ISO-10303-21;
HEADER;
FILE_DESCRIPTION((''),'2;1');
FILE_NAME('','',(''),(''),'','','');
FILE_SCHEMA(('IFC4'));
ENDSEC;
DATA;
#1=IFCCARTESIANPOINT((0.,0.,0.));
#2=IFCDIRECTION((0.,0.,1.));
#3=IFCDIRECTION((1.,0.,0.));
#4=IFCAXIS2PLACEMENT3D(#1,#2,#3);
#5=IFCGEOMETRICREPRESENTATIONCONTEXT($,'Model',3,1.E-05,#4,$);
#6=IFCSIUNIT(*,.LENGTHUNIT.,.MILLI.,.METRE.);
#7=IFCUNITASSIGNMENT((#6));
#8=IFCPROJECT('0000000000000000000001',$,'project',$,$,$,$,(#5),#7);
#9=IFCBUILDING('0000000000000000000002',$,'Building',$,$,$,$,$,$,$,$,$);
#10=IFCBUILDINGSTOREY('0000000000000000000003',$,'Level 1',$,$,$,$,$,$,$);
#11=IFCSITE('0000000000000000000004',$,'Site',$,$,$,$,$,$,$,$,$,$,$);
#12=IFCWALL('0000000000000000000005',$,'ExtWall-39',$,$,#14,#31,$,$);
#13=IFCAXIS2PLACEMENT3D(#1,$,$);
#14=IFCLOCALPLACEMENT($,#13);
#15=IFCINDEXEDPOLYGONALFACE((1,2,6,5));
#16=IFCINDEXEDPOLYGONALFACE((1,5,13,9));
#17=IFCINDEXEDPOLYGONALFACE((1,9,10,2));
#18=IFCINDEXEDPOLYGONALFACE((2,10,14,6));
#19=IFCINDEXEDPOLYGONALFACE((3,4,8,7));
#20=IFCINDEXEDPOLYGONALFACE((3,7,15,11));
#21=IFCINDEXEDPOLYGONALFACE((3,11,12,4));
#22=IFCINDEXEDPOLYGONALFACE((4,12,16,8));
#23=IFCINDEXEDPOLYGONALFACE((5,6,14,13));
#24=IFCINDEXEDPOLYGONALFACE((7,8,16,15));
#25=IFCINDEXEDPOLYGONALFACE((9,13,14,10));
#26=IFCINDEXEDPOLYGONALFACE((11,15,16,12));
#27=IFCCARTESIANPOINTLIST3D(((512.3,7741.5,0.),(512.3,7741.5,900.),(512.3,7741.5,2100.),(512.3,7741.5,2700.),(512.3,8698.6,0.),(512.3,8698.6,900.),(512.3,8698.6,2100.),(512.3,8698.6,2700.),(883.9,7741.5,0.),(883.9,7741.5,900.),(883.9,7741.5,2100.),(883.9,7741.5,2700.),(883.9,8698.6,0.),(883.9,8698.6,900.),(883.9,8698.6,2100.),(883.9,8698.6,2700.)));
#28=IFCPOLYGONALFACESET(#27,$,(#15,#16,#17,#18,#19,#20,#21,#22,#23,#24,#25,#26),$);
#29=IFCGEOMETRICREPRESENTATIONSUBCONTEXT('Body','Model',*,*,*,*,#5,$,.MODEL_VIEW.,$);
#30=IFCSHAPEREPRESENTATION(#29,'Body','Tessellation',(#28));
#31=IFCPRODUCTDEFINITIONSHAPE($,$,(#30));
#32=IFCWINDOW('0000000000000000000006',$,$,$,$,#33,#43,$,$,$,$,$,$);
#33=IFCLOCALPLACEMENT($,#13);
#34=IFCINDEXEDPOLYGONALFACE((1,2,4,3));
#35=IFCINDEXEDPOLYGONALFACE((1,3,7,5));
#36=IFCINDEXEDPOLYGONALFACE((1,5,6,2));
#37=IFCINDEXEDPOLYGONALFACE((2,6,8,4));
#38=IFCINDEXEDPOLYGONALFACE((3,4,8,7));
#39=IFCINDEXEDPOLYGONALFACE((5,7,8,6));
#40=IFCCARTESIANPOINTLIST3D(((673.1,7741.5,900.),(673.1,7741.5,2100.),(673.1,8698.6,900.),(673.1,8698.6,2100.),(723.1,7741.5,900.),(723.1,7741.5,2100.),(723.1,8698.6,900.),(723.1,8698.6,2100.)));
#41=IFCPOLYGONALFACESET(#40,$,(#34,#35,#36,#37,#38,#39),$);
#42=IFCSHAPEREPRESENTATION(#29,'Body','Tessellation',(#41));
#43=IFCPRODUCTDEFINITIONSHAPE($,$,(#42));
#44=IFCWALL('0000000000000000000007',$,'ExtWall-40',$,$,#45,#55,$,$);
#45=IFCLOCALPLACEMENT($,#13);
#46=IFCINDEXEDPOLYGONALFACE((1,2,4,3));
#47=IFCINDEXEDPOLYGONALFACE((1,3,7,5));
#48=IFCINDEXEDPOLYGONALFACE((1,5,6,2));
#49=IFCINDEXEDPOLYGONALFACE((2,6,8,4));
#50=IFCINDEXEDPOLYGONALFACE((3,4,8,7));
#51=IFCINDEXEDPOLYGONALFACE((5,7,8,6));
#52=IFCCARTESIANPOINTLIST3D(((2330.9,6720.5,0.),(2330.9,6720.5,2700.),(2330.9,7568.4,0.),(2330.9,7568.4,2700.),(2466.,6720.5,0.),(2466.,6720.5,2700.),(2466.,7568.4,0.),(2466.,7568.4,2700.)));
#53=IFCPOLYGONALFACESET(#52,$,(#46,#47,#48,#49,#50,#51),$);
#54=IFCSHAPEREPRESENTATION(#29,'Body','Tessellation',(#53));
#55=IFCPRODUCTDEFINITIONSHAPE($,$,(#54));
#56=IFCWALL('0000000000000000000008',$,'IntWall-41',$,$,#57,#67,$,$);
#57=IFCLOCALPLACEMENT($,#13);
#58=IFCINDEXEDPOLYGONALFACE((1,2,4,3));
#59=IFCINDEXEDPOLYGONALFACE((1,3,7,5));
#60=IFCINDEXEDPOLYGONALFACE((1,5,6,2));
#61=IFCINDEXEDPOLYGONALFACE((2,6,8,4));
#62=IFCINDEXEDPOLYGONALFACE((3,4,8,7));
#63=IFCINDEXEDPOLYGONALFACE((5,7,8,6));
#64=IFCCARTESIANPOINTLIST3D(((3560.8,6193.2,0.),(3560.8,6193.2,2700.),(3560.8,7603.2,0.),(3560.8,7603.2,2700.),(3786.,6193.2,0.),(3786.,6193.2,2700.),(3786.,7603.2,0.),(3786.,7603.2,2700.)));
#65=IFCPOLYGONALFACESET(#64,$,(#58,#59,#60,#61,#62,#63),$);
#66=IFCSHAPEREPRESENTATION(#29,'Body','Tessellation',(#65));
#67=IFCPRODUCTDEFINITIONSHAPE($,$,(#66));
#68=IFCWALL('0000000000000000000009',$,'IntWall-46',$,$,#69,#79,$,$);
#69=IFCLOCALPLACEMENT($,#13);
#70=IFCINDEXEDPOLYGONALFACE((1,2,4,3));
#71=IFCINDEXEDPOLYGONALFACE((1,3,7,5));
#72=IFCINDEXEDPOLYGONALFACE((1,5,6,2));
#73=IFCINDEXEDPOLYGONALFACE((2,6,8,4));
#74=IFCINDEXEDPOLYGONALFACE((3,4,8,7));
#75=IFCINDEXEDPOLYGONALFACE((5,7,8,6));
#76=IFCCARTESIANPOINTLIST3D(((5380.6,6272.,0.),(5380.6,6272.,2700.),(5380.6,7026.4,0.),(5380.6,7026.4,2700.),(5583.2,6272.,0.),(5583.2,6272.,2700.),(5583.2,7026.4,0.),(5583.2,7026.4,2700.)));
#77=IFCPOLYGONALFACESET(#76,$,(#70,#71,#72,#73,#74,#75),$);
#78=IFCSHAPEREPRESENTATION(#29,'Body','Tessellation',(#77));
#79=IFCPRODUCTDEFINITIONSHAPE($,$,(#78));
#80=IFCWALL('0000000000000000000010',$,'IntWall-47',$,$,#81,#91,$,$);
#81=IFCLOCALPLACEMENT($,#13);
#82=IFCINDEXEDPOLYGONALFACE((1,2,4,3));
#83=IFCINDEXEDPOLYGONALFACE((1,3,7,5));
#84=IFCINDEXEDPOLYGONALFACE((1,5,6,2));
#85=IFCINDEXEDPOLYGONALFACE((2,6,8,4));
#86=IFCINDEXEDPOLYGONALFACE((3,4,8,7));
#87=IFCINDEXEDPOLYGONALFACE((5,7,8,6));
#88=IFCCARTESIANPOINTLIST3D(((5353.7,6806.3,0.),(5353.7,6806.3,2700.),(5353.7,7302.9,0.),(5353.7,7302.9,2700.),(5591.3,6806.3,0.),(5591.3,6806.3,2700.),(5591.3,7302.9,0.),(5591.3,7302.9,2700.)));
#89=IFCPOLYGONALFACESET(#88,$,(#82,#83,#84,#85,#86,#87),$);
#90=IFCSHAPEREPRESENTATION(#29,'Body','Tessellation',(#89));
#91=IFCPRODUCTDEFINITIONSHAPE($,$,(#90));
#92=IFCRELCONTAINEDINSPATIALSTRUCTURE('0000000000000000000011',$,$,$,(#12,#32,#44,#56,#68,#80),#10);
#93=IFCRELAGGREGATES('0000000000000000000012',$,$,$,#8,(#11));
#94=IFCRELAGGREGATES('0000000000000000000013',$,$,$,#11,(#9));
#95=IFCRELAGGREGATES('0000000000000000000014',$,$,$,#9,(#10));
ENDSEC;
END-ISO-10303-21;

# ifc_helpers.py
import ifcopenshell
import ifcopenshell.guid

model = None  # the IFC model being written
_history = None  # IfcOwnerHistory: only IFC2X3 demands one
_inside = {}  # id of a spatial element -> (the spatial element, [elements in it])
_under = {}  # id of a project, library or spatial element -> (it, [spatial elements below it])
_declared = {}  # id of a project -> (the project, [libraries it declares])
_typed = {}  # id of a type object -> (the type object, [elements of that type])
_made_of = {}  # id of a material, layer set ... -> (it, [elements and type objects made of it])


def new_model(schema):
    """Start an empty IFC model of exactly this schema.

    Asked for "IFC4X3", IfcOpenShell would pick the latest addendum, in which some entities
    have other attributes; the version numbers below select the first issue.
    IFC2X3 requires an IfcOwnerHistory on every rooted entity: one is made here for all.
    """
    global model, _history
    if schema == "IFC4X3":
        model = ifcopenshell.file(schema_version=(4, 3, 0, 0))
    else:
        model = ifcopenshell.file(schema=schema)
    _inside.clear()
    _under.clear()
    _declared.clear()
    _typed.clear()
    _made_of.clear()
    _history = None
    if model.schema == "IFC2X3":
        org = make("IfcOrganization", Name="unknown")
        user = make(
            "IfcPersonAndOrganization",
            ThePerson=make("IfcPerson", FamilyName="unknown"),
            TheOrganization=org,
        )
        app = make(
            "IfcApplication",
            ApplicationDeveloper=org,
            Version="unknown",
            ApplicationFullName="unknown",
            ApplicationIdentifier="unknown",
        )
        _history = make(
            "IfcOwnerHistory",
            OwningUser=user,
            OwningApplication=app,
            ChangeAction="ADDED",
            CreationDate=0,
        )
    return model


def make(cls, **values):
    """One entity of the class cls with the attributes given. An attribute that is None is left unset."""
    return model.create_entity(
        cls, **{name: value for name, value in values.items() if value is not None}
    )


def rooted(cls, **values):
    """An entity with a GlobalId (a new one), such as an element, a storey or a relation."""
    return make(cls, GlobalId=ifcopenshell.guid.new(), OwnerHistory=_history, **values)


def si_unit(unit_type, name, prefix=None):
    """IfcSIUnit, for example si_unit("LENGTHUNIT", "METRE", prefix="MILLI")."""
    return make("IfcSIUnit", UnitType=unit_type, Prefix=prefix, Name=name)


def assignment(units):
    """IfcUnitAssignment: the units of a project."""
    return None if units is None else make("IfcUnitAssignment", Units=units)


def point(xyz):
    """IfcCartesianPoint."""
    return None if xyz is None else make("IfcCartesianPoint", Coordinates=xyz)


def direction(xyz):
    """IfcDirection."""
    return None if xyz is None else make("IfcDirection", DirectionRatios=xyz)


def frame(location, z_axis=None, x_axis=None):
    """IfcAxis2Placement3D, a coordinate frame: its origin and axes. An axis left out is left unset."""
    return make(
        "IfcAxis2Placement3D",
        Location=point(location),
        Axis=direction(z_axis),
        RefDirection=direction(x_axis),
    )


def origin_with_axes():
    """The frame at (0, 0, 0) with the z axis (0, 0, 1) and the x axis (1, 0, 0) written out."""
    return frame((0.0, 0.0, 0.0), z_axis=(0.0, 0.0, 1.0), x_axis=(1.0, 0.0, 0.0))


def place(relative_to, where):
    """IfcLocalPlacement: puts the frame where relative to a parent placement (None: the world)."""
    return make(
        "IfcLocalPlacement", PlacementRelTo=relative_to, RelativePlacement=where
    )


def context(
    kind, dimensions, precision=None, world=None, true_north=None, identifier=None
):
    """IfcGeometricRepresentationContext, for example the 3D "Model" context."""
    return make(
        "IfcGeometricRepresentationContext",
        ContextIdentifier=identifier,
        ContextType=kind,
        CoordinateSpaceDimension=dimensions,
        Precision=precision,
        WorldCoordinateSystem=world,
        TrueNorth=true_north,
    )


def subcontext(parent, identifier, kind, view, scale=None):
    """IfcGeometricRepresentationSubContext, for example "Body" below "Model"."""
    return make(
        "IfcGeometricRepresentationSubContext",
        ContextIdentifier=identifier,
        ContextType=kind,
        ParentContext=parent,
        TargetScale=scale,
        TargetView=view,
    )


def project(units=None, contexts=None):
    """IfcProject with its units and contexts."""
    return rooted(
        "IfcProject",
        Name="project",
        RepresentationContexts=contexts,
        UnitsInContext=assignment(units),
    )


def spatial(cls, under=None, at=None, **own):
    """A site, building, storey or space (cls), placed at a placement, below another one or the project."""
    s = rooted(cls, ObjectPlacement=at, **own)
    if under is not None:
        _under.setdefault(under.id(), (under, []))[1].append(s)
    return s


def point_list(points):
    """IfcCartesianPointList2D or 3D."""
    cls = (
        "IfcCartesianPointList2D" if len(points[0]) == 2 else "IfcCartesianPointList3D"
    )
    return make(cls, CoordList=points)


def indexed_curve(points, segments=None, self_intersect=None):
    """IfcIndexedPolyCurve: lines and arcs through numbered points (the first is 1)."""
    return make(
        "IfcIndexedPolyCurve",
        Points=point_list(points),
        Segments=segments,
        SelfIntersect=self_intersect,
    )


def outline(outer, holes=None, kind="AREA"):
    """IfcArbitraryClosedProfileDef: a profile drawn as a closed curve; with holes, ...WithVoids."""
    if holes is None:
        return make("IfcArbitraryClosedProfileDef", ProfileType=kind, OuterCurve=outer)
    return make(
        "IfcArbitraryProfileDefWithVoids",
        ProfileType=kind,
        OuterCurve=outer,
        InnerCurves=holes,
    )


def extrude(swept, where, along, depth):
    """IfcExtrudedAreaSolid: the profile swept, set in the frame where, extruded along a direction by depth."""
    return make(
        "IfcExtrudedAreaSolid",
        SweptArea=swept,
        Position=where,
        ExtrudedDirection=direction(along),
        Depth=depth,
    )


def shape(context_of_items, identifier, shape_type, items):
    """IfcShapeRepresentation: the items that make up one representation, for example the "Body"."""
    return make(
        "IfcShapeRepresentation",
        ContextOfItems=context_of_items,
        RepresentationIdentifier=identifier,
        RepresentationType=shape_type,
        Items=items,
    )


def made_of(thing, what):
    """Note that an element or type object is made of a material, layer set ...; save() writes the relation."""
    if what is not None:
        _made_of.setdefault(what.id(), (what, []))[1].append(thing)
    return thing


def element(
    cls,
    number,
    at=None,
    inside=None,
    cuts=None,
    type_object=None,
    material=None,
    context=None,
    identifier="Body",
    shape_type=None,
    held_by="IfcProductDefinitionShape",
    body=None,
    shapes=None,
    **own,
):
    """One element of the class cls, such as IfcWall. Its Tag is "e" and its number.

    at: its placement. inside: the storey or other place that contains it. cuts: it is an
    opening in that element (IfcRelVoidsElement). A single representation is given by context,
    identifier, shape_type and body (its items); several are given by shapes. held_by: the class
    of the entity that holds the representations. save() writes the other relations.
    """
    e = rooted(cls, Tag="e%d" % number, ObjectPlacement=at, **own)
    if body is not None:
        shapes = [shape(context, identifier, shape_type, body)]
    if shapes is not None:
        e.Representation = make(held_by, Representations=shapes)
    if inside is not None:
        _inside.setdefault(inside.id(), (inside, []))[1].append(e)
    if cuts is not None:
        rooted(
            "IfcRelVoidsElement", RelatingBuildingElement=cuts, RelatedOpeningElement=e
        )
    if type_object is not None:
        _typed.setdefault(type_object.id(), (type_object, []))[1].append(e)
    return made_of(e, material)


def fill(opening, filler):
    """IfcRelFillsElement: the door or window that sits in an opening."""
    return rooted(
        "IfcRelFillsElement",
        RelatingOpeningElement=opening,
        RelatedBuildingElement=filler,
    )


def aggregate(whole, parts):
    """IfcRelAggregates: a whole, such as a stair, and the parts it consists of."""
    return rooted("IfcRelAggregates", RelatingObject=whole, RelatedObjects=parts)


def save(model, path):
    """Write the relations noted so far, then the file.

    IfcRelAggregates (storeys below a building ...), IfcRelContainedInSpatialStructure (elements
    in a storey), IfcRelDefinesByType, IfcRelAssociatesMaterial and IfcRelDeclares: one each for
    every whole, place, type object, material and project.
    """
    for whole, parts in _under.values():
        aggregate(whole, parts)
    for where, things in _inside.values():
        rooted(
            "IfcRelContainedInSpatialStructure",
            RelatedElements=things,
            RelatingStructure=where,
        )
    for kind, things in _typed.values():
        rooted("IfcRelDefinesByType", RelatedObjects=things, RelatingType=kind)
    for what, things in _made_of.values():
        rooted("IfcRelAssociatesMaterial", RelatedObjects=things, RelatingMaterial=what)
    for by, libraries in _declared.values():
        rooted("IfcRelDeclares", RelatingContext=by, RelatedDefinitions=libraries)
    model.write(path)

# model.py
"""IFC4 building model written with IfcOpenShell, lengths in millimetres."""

from ifc_helpers import new_model, si_unit, frame, origin_with_axes, place, context, subcontext, project, spatial, indexed_curve, outline, extrude, element, fill, save


model = new_model("IFC4")

# Units and contexts
model_context = context("Model", 3, precision=1e-05, world=origin_with_axes())
body_context = subcontext(model_context, "Body", "Model", "MODEL_VIEW")
ifc_project = project(units=[si_unit("LENGTHUNIT", "METRE", prefix="MILLI")], contexts=[model_context])

# Site, building, storey
site = spatial("IfcSite", under=ifc_project, Name="Site")
building = spatial("IfcBuilding", under=site, Name="Building")
storey = spatial("IfcBuildingStorey", under=building, Name="Level 1")

# Wall, opening, window
wall_1_placement = place(None, frame((698.1, 7741.5, 0.0), z_axis=(0.0, 0.0, 1.0), x_axis=(0.0, 1.0, 0.0)))
wall_1 = element("IfcWall", 1, at=wall_1_placement, inside=storey, Name="ExtWall-39", context=body_context, shape_type="SweptSolid", body=[
    extrude(outline(indexed_curve([(0.0, 0.0), (0.0, 371.6), (957.1, 371.6), (957.1, 0.0), (0.0, 0.0)], self_intersect=False)), frame((0.0, -185.8, 0.0), z_axis=(0.0, 0.0, 1.0), x_axis=(1.0, 0.0, 0.0)), (0.0, 0.0, 1.0), 2700.0),
])
opening_1_placement = place(wall_1_placement, frame((0.0, 0.0, 900.0), z_axis=(0.0, 0.0, 1.0), x_axis=(1.0, 0.0, 0.0)))
opening_1 = element("IfcOpeningElement", 2, at=opening_1_placement, cuts=wall_1, context=body_context, shape_type="SweptSolid", body=[
    extrude(outline(indexed_curve([(0.0, 0.0), (0.0, 471.6), (957.1, 471.6), (957.1, 0.0), (0.0, 0.0)], self_intersect=False)), frame((0.0, -235.8, 0.0), z_axis=(0.0, 0.0, 1.0), x_axis=(1.0, 0.0, 0.0)), (0.0, 0.0, 1.0), 1200.0),
])
window_placement = place(opening_1_placement, origin_with_axes())
window = element("IfcWindow", 3, at=window_placement, inside=storey, context=body_context, shape_type="SweptSolid", body=[
    extrude(outline(indexed_curve([(0.0, 0.0), (0.0, 50.0), (957.1, 50.0), (957.1, 0.0), (0.0, 0.0)], self_intersect=False)), frame((0.0, -25.0, 0.0), z_axis=(0.0, 0.0, 1.0), x_axis=(1.0, 0.0, 0.0)), (0.0, 0.0, 1.0), 1200.0),
])
fill(opening_1, window)

# Walls
wall_2_placement = place(None, frame((2398.4, 6720.5, 0.0), z_axis=(0.0, 0.0, 1.0), x_axis=(0.0, 1.0, 0.0)))
element("IfcWall", 4, at=wall_2_placement, inside=storey, Name="ExtWall-40", context=body_context, shape_type="SweptSolid", body=[
    extrude(outline(indexed_curve([(0.0, 0.0), (0.0, 135.1), (847.9, 135.1), (847.9, 0.0), (0.0, 0.0)], self_intersect=False)), frame((0.0, -67.6, 0.0), z_axis=(0.0, 0.0, 1.0), x_axis=(1.0, 0.0, 0.0)), (0.0, 0.0, 1.0), 2700.0),
])
wall_3_placement = place(None, frame((3673.4, 6193.2, 0.0), z_axis=(0.0, 0.0, 1.0), x_axis=(0.0, 1.0, 0.0)))
element("IfcWall", 5, at=wall_3_placement, inside=storey, Name="IntWall-41", context=body_context, shape_type="SweptSolid", body=[
    extrude(outline(indexed_curve([(0.0, 0.0), (0.0, 225.2), (1410.0, 225.2), (1410.0, 0.0), (0.0, 0.0)], self_intersect=False)), frame((0.0, -112.6, 0.0), z_axis=(0.0, 0.0, 1.0), x_axis=(1.0, 0.0, 0.0)), (0.0, 0.0, 1.0), 2700.0),
])
wall_4_placement = place(None, frame((5481.9, 6272.0, 0.0), z_axis=(0.0, 0.0, 1.0), x_axis=(0.0, 1.0, 0.0)))
element("IfcWall", 6, at=wall_4_placement, inside=storey, Name="IntWall-46", context=body_context, shape_type="SweptSolid", body=[
    extrude(outline(indexed_curve([(0.0, 0.0), (0.0, 202.7), (754.4, 202.7), (754.4, 0.0), (0.0, 0.0)], self_intersect=False)), frame((0.0, -101.3, 0.0), z_axis=(0.0, 0.0, 1.0), x_axis=(1.0, 0.0, 0.0)), (0.0, 0.0, 1.0), 2700.0),
])
wall_5_placement = place(None, frame((5472.5, 6806.3, 0.0), z_axis=(0.0, 0.0, 1.0), x_axis=(0.0, 1.0, 0.0)))
element("IfcWall", 7, at=wall_5_placement, inside=storey, Name="IntWall-47", context=body_context, shape_type="SweptSolid", body=[
    extrude(outline(indexed_curve([(0.0, 0.0), (0.0, 237.6), (496.6, 237.6), (496.6, 0.0), (0.0, 0.0)], self_intersect=False)), frame((0.0, -118.8, 0.0), z_axis=(0.0, 0.0, 1.0), x_axis=(1.0, 0.0, 0.0)), (0.0, 0.0, 1.0), 2700.0),
])

save(model, "model.ifc")
